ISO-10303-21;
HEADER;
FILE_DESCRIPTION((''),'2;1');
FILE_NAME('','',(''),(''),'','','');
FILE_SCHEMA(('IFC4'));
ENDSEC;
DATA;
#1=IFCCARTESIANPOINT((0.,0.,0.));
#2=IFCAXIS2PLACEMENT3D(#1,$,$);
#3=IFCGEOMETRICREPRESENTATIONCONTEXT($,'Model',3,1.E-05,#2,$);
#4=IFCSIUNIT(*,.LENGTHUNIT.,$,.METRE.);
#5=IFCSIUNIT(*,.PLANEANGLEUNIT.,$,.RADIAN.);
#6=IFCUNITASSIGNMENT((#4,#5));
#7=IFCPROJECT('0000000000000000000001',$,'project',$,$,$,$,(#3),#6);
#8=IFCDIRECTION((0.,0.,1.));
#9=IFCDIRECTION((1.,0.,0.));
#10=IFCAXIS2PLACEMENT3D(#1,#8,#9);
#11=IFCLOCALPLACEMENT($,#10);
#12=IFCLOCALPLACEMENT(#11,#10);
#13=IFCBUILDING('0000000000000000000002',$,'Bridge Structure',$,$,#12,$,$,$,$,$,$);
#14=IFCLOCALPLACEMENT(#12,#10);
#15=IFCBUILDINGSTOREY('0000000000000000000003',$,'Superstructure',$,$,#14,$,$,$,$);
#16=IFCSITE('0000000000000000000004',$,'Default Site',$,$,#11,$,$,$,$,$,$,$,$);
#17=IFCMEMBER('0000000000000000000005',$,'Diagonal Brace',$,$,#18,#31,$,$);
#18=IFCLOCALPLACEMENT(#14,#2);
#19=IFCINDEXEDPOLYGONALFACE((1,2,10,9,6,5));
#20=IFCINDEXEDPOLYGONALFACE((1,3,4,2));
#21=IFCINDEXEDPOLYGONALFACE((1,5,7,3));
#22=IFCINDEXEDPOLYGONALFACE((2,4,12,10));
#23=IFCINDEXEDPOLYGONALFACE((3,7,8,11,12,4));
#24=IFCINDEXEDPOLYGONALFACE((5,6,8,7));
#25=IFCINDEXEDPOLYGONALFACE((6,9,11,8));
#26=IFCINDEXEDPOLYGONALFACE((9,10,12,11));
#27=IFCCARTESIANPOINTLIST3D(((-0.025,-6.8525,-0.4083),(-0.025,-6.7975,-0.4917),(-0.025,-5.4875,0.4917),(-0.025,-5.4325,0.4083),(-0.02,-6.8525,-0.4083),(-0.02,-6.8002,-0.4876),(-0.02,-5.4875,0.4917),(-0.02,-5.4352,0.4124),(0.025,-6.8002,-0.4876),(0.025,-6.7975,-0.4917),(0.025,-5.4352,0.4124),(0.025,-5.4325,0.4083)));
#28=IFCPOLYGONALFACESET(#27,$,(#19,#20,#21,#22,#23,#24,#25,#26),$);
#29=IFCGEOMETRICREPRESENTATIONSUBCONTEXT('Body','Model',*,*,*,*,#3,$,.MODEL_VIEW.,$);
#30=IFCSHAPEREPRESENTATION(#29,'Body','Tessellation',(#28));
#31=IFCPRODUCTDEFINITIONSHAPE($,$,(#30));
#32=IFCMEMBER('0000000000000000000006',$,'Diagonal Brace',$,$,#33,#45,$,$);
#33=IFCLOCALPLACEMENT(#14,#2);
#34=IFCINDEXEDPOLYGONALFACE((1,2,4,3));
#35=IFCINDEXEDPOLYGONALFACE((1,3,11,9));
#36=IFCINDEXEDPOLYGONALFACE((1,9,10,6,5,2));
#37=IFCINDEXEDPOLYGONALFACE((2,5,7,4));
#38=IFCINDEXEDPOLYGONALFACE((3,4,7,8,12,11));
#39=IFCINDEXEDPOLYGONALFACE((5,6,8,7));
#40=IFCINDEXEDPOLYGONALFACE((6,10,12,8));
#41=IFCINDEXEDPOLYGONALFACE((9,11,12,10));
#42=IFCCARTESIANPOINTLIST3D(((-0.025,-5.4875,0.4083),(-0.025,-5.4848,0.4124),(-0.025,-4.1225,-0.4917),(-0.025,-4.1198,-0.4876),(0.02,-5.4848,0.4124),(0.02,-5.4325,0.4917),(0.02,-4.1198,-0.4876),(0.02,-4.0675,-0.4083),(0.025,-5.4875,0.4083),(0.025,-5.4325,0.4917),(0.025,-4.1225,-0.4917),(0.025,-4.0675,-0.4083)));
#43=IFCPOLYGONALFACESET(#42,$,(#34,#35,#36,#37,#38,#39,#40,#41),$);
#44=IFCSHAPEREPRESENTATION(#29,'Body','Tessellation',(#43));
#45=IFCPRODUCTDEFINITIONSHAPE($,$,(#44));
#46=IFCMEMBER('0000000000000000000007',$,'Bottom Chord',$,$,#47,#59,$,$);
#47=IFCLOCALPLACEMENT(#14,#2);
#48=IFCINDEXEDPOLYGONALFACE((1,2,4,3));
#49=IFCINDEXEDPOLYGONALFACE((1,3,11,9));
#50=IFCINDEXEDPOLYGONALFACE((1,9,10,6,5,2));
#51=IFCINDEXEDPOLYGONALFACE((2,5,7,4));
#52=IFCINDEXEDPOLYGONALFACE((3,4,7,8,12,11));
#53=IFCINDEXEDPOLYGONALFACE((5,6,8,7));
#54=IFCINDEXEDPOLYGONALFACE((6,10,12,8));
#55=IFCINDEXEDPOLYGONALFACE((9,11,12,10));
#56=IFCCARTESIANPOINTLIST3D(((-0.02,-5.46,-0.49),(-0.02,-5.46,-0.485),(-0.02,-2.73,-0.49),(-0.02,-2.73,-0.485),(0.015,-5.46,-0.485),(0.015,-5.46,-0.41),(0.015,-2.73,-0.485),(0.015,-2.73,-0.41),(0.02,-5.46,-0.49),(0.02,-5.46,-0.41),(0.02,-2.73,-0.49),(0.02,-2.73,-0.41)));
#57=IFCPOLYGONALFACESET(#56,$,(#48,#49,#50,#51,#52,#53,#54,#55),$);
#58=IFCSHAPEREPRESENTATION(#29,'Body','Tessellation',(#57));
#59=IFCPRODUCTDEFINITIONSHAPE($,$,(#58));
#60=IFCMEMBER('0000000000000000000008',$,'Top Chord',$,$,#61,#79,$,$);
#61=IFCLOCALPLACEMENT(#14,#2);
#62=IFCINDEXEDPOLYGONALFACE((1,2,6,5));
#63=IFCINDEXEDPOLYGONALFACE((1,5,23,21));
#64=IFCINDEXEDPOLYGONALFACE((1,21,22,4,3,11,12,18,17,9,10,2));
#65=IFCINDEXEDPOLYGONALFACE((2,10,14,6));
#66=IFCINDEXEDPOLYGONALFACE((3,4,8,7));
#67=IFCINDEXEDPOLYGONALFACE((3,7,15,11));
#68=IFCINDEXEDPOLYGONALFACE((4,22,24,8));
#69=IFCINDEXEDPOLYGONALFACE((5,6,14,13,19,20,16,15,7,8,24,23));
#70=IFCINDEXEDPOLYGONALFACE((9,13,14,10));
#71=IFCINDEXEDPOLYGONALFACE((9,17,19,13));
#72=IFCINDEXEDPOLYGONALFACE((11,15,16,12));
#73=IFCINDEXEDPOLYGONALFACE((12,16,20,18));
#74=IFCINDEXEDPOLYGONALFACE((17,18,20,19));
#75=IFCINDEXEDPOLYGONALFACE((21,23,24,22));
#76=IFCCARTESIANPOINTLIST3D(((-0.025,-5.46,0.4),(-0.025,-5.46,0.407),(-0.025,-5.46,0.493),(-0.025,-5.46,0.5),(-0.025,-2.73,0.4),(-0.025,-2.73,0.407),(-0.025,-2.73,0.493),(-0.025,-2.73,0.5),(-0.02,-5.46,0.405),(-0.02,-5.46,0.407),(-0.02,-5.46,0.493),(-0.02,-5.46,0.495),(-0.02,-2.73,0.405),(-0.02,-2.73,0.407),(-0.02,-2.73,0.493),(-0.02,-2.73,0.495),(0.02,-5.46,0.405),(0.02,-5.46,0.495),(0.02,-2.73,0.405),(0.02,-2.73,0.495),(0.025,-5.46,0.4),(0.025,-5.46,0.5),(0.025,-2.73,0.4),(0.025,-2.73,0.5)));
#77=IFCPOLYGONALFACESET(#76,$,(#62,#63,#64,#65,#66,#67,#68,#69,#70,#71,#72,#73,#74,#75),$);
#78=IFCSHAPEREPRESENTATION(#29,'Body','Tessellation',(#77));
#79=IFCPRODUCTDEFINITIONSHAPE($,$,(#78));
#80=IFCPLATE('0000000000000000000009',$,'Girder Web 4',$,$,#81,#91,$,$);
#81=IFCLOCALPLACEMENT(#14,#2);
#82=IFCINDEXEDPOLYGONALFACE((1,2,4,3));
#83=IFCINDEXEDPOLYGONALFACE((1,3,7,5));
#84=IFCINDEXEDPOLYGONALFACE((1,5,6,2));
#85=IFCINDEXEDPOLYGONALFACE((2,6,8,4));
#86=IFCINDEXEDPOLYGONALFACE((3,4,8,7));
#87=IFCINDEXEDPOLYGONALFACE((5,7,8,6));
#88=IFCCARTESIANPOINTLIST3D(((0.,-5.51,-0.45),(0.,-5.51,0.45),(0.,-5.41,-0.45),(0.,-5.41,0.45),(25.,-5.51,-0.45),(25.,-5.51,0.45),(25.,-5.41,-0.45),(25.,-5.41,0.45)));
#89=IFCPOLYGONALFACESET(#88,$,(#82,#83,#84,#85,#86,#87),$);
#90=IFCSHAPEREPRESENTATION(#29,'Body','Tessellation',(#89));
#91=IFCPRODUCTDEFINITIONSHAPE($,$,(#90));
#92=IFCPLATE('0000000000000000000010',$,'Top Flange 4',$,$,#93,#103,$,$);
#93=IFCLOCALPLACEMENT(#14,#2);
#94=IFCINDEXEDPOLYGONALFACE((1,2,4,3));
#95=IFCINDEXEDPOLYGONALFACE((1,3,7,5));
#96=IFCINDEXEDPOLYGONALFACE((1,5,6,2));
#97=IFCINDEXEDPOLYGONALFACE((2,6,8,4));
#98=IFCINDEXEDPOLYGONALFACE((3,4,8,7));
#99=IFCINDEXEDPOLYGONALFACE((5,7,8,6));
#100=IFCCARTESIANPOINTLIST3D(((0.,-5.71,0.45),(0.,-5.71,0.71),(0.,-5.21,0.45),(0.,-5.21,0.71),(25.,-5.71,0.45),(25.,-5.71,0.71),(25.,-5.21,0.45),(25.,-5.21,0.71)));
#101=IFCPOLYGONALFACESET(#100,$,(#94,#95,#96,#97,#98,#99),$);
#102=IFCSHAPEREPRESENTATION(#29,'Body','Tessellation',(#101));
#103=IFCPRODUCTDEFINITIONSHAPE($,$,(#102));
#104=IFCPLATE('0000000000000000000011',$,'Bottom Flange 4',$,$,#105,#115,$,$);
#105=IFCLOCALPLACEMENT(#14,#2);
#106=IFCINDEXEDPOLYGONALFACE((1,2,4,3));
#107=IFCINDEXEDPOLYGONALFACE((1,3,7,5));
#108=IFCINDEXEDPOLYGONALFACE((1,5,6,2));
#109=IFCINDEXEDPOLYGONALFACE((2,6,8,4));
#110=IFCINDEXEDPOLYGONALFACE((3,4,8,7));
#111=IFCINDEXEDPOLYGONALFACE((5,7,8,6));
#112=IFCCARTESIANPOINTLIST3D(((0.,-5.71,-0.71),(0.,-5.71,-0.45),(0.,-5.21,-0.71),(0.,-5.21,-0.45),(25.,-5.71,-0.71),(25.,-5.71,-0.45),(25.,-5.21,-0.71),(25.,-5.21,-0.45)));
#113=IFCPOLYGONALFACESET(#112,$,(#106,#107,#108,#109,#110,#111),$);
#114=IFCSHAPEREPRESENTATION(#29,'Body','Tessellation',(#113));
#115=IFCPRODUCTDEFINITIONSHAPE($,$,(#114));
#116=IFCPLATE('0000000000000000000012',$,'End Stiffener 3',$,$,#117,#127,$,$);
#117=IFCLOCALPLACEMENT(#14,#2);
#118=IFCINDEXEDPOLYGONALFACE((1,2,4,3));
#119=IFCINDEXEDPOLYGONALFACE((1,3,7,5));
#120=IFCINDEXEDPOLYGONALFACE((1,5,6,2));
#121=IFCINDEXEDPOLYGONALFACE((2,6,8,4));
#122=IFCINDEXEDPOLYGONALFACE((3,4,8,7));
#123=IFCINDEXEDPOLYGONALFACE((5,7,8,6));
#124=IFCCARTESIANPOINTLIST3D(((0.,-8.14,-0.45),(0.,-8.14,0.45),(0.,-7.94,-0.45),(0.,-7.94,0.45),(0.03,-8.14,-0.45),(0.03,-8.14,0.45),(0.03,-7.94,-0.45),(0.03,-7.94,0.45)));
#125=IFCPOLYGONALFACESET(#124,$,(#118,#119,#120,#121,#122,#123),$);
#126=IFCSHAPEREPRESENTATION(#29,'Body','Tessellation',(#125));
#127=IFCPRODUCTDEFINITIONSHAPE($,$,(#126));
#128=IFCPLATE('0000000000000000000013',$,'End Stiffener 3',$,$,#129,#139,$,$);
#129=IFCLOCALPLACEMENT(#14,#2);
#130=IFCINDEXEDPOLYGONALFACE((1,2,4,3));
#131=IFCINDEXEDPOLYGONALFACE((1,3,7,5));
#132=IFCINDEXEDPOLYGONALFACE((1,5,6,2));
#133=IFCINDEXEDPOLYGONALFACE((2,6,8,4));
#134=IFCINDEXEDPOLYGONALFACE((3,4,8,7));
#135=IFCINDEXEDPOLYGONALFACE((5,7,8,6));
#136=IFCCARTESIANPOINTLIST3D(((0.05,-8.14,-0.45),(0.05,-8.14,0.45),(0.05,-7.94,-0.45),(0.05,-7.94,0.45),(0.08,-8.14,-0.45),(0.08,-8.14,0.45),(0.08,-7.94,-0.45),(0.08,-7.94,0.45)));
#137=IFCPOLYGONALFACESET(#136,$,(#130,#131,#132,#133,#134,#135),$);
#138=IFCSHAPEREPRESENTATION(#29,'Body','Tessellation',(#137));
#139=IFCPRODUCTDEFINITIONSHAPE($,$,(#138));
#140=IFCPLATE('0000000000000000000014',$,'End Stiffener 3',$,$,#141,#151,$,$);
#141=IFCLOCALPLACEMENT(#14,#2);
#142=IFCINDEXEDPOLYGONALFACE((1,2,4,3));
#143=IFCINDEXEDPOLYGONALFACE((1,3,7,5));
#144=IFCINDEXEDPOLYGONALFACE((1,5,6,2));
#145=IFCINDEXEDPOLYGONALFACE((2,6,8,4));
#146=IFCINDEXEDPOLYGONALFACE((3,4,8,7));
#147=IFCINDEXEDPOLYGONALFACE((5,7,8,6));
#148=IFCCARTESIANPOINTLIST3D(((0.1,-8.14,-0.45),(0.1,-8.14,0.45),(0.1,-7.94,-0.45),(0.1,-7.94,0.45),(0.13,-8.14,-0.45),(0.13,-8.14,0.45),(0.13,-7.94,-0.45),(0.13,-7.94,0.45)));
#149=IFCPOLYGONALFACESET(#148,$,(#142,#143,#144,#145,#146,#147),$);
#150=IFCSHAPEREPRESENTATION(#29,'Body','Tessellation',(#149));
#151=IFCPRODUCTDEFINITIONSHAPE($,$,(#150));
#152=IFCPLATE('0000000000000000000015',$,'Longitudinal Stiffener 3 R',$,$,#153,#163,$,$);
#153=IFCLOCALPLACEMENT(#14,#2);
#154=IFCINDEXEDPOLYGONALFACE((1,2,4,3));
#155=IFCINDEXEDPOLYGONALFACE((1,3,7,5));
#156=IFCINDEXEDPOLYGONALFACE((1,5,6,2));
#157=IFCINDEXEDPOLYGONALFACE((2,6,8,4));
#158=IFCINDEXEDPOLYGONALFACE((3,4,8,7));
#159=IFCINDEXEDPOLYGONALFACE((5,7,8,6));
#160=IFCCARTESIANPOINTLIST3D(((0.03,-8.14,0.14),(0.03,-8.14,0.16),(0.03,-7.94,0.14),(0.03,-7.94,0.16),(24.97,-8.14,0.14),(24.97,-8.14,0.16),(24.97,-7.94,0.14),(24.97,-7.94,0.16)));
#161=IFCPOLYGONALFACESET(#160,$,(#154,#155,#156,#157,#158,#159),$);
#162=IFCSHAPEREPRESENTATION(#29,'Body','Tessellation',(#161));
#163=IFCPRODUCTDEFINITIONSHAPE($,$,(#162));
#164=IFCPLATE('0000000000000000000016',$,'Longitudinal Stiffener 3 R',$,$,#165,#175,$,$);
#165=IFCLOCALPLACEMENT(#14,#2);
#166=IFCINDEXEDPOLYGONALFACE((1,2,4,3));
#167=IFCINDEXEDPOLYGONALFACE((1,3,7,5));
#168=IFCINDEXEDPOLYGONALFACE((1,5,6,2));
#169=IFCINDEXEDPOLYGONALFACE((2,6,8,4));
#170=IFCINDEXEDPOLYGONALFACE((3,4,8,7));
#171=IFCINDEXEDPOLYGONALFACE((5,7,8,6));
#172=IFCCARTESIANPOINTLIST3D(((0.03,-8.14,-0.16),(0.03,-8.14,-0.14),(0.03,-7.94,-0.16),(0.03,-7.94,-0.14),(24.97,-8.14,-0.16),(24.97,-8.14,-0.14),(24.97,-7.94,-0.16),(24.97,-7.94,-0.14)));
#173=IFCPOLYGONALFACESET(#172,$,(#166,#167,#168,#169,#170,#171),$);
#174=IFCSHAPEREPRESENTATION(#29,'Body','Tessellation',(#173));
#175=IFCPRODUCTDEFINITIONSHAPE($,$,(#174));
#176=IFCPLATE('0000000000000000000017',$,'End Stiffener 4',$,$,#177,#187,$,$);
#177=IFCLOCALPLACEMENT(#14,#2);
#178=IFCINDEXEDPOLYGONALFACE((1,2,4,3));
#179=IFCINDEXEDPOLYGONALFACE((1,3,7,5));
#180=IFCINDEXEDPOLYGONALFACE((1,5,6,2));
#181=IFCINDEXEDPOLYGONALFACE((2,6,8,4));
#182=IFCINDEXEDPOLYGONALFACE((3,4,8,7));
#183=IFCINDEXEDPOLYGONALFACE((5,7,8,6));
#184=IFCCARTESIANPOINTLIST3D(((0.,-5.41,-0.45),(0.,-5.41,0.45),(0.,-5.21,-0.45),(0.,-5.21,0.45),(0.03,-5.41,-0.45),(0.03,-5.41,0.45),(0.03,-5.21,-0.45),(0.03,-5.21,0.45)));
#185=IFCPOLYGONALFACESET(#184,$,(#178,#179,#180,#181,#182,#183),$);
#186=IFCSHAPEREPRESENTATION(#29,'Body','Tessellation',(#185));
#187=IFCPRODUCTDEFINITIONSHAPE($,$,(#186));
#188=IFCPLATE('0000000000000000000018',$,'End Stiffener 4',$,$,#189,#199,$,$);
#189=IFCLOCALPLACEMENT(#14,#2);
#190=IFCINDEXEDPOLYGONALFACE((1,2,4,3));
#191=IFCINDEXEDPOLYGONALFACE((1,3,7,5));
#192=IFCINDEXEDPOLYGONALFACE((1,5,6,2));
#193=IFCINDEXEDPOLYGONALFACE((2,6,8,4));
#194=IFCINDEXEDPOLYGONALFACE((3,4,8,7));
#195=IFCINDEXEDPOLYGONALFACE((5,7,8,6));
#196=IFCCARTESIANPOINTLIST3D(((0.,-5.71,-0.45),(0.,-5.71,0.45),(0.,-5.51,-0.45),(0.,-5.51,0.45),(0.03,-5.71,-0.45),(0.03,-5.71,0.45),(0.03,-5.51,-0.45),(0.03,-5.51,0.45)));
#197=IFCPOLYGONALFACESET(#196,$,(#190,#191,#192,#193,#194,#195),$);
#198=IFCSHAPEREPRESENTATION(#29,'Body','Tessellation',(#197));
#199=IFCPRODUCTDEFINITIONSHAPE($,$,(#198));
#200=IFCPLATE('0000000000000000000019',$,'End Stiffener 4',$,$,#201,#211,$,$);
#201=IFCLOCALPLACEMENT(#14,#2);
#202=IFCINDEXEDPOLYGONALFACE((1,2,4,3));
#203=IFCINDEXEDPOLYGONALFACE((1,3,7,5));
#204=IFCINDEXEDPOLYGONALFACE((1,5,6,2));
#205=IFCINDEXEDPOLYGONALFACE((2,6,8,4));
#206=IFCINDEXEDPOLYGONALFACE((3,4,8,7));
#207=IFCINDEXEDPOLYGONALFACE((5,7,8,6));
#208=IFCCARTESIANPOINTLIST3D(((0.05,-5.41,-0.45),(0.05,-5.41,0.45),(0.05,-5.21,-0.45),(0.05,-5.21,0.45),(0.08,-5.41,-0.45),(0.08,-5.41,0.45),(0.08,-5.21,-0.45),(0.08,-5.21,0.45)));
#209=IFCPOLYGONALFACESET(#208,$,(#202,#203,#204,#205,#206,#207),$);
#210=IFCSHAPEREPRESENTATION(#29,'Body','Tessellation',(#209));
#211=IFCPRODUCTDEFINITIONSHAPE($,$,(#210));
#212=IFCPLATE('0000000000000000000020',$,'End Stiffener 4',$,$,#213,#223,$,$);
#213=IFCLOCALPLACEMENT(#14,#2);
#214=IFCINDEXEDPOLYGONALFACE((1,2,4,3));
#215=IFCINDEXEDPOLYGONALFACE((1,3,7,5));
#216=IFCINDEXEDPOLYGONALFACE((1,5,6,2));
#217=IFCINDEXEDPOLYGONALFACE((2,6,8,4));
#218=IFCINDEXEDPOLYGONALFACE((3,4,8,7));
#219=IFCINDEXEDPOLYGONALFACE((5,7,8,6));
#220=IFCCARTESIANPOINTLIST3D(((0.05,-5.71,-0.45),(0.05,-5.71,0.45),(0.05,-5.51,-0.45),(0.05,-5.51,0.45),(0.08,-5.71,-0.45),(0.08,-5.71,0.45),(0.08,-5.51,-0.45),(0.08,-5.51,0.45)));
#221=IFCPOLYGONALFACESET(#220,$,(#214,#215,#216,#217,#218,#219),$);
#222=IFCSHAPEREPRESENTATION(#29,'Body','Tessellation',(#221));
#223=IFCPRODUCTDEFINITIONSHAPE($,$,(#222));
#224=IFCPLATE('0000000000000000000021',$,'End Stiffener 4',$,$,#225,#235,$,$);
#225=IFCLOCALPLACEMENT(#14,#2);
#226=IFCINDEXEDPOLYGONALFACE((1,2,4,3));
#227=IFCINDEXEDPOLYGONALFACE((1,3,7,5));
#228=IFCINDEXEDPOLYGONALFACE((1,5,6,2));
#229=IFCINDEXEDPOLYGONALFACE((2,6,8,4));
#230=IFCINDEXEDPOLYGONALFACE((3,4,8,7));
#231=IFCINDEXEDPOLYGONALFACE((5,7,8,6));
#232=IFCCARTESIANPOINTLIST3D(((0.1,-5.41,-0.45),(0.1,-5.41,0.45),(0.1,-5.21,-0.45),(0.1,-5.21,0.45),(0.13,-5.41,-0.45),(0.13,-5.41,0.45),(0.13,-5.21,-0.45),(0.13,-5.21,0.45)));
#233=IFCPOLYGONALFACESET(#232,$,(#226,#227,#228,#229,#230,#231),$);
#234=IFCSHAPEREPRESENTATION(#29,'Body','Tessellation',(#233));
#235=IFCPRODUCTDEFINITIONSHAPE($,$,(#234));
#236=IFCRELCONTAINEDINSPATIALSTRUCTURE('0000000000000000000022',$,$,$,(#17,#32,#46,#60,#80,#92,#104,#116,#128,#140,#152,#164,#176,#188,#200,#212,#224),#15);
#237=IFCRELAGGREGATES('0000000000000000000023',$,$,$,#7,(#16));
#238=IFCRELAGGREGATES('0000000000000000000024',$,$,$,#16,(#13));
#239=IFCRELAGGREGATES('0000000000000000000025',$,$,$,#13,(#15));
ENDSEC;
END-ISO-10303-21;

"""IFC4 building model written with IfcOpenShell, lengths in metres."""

from ifc_helpers import new_model, si_unit, frame, origin, origin_with_axes, origin_2d_with_axis, place, context, subcontext, project, spatial, rectangle, l_section, c_section, extrude, element, save


model = new_model("IFC4")

# Units and contexts
model_context = context("Model", 3, precision=1e-05, world=origin())
body_context = subcontext(model_context, "Body", "Model", "MODEL_VIEW")
ifc_project = project(units=[si_unit("LENGTHUNIT", "METRE"), si_unit("PLANEANGLEUNIT", "RADIAN")], contexts=[model_context])

# Site, building, storey
site_placement = place(None, origin_with_axes())
site = spatial("IfcSite", under=ifc_project, at=site_placement, Name="Default Site")
building_placement = place(site_placement, origin_with_axes())
building = spatial("IfcBuilding", under=site, at=building_placement, Name="Bridge Structure")
storey_placement = place(building_placement, origin_with_axes())
storey = spatial("IfcBuildingStorey", under=building, at=storey_placement, Name="Superstructure")

# Members
for number, where, z_axis, x_axis, name in (
    (1, (0.0, -5.46, 0.45), (0.0, -0.834862, -0.550459), (1.0, 0.0, 0.0), "Diagonal Brace"),
    (2, (0.0, -5.46, 0.45), (0.0, 0.834862, -0.550459), (-1.0, 0.0, 0.0), "Diagonal Brace"),
):
    element("IfcMember", number, at=place(storey_placement, frame(where, z_axis=z_axis, x_axis=x_axis)), inside=storey, Name=name, context=body_context, shape_type="SweptSolid", body=[
        extrude(l_section(Depth=0.1, Width=0.05, Thickness=0.005, at=origin_2d_with_axis()), origin_with_axes(), (0.0, 0.0, 1.0), 1.635),
    ])
member_1_placement = place(storey_placement, frame((0.0, -5.46, -0.45), z_axis=(0.0, 1.0, 0.0), x_axis=(-1.0, 0.0, 0.0)))
element("IfcMember", 3, at=member_1_placement, inside=storey, Name="Bottom Chord", context=body_context, shape_type="SweptSolid", body=[
    extrude(l_section(Depth=0.08, Width=0.04, Thickness=0.005, at=origin_2d_with_axis()), origin_with_axes(), (0.0, 0.0, 1.0), 2.73),
])
member_2_placement = place(storey_placement, frame((0.0, -5.46, 0.45), z_axis=(0.0, 1.0, 0.0), x_axis=(-1.0, 0.0, 0.0)))
element("IfcMember", 4, at=member_2_placement, inside=storey, Name="Top Chord", context=body_context, shape_type="SweptSolid", body=[
    extrude(c_section(Depth=0.1, Width=0.05, WallThickness=0.005, Girth=0.007, at=origin_2d_with_axis()), origin_with_axes(), (0.0, 0.0, 1.0), 2.73),
])

# Plates
plate_1_placement = place(storey_placement, frame((0.0, -5.46, 0.0), z_axis=(1.0, 0.0, 0.0), x_axis=(0.0, 1.0, 0.0)))
element("IfcPlate", 5, at=plate_1_placement, inside=storey, Name="Girder Web 4", context=body_context, shape_type="SweptSolid", body=[
    extrude(rectangle(XDim=0.1, YDim=0.9, at=origin_2d_with_axis()), origin_with_axes(), (0.0, 0.0, 1.0), 25.0),
])
for number, where, z_axis, x_axis, name in (
    (6, (0.0, -5.46, 0.58), (1.0, 0.0, 0.0), (0.0, 1.0, 0.0), "Top Flange 4"),
    (7, (0.0, -5.46, -0.58), (1.0, 0.0, 0.0), (0.0, 1.0, 0.0), "Bottom Flange 4"),
):
    element("IfcPlate", number, at=place(storey_placement, frame(where, z_axis=z_axis, x_axis=x_axis)), inside=storey, Name=name, context=body_context, shape_type="SweptSolid", body=[
        extrude(rectangle(XDim=0.5, YDim=0.26, at=origin_2d_with_axis()), origin_with_axes(), (0.0, 0.0, 1.0), 25.0),
    ])
for number, where, z_axis, x_axis, name in (
    (8, (0.015, -8.04, -0.45), (0.0, 0.0, 1.0), (1.0, 0.0, 0.0), "End Stiffener 3"),
    (9, (0.065, -8.04, -0.45), (0.0, 0.0, 1.0), (1.0, 0.0, 0.0), "End Stiffener 3"),
    (10, (0.115, -8.04, -0.45), (0.0, 0.0, 1.0), (1.0, 0.0, 0.0), "End Stiffener 3"),
):
    element("IfcPlate", number, at=place(storey_placement, frame(where, z_axis=z_axis, x_axis=x_axis)), inside=storey, Name=name, context=body_context, shape_type="SweptSolid", body=[
        extrude(rectangle(XDim=0.03, YDim=0.2, at=origin_2d_with_axis()), origin_with_axes(), (0.0, 0.0, 1.0), 0.9),
    ])
for number, where, z_axis, x_axis, name in (
    (11, (0.03, -8.04, 0.15), (1.0, 0.0, 0.0), (0.0, 1.0, 0.0), "Longitudinal Stiffener 3 R"),
    (12, (0.03, -8.04, -0.15), (1.0, 0.0, 0.0), (0.0, 1.0, 0.0), "Longitudinal Stiffener 3 R"),
):
    element("IfcPlate", number, at=place(storey_placement, frame(where, z_axis=z_axis, x_axis=x_axis)), inside=storey, Name=name, context=body_context, shape_type="SweptSolid", body=[
        extrude(rectangle(XDim=0.2, YDim=0.02, at=origin_2d_with_axis()), origin_with_axes(), (0.0, 0.0, 1.0), 24.94),
    ])
for number, where, z_axis, x_axis, name in (
    (13, (0.015, -5.31, -0.45), (0.0, 0.0, 1.0), (1.0, 0.0, 0.0), "End Stiffener 4"),
    (14, (0.015, -5.61, -0.45), (0.0, 0.0, 1.0), (1.0, 0.0, 0.0), "End Stiffener 4"),
    (15, (0.065, -5.31, -0.45), (0.0, 0.0, 1.0), (1.0, 0.0, 0.0), "End Stiffener 4"),
    (16, (0.065, -5.61, -0.45), (0.0, 0.0, 1.0), (1.0, 0.0, 0.0), "End Stiffener 4"),
    (17, (0.115, -5.31, -0.45), (0.0, 0.0, 1.0), (1.0, 0.0, 0.0), "End Stiffener 4"),
):
    element("IfcPlate", number, at=place(storey_placement, frame(where, z_axis=z_axis, x_axis=x_axis)), inside=storey, Name=name, context=body_context, shape_type="SweptSolid", body=[
        extrude(rectangle(XDim=0.03, YDim=0.2, at=origin_2d_with_axis()), origin_with_axes(), (0.0, 0.0, 1.0), 0.9),
    ])

save(model, "model.ifc")
